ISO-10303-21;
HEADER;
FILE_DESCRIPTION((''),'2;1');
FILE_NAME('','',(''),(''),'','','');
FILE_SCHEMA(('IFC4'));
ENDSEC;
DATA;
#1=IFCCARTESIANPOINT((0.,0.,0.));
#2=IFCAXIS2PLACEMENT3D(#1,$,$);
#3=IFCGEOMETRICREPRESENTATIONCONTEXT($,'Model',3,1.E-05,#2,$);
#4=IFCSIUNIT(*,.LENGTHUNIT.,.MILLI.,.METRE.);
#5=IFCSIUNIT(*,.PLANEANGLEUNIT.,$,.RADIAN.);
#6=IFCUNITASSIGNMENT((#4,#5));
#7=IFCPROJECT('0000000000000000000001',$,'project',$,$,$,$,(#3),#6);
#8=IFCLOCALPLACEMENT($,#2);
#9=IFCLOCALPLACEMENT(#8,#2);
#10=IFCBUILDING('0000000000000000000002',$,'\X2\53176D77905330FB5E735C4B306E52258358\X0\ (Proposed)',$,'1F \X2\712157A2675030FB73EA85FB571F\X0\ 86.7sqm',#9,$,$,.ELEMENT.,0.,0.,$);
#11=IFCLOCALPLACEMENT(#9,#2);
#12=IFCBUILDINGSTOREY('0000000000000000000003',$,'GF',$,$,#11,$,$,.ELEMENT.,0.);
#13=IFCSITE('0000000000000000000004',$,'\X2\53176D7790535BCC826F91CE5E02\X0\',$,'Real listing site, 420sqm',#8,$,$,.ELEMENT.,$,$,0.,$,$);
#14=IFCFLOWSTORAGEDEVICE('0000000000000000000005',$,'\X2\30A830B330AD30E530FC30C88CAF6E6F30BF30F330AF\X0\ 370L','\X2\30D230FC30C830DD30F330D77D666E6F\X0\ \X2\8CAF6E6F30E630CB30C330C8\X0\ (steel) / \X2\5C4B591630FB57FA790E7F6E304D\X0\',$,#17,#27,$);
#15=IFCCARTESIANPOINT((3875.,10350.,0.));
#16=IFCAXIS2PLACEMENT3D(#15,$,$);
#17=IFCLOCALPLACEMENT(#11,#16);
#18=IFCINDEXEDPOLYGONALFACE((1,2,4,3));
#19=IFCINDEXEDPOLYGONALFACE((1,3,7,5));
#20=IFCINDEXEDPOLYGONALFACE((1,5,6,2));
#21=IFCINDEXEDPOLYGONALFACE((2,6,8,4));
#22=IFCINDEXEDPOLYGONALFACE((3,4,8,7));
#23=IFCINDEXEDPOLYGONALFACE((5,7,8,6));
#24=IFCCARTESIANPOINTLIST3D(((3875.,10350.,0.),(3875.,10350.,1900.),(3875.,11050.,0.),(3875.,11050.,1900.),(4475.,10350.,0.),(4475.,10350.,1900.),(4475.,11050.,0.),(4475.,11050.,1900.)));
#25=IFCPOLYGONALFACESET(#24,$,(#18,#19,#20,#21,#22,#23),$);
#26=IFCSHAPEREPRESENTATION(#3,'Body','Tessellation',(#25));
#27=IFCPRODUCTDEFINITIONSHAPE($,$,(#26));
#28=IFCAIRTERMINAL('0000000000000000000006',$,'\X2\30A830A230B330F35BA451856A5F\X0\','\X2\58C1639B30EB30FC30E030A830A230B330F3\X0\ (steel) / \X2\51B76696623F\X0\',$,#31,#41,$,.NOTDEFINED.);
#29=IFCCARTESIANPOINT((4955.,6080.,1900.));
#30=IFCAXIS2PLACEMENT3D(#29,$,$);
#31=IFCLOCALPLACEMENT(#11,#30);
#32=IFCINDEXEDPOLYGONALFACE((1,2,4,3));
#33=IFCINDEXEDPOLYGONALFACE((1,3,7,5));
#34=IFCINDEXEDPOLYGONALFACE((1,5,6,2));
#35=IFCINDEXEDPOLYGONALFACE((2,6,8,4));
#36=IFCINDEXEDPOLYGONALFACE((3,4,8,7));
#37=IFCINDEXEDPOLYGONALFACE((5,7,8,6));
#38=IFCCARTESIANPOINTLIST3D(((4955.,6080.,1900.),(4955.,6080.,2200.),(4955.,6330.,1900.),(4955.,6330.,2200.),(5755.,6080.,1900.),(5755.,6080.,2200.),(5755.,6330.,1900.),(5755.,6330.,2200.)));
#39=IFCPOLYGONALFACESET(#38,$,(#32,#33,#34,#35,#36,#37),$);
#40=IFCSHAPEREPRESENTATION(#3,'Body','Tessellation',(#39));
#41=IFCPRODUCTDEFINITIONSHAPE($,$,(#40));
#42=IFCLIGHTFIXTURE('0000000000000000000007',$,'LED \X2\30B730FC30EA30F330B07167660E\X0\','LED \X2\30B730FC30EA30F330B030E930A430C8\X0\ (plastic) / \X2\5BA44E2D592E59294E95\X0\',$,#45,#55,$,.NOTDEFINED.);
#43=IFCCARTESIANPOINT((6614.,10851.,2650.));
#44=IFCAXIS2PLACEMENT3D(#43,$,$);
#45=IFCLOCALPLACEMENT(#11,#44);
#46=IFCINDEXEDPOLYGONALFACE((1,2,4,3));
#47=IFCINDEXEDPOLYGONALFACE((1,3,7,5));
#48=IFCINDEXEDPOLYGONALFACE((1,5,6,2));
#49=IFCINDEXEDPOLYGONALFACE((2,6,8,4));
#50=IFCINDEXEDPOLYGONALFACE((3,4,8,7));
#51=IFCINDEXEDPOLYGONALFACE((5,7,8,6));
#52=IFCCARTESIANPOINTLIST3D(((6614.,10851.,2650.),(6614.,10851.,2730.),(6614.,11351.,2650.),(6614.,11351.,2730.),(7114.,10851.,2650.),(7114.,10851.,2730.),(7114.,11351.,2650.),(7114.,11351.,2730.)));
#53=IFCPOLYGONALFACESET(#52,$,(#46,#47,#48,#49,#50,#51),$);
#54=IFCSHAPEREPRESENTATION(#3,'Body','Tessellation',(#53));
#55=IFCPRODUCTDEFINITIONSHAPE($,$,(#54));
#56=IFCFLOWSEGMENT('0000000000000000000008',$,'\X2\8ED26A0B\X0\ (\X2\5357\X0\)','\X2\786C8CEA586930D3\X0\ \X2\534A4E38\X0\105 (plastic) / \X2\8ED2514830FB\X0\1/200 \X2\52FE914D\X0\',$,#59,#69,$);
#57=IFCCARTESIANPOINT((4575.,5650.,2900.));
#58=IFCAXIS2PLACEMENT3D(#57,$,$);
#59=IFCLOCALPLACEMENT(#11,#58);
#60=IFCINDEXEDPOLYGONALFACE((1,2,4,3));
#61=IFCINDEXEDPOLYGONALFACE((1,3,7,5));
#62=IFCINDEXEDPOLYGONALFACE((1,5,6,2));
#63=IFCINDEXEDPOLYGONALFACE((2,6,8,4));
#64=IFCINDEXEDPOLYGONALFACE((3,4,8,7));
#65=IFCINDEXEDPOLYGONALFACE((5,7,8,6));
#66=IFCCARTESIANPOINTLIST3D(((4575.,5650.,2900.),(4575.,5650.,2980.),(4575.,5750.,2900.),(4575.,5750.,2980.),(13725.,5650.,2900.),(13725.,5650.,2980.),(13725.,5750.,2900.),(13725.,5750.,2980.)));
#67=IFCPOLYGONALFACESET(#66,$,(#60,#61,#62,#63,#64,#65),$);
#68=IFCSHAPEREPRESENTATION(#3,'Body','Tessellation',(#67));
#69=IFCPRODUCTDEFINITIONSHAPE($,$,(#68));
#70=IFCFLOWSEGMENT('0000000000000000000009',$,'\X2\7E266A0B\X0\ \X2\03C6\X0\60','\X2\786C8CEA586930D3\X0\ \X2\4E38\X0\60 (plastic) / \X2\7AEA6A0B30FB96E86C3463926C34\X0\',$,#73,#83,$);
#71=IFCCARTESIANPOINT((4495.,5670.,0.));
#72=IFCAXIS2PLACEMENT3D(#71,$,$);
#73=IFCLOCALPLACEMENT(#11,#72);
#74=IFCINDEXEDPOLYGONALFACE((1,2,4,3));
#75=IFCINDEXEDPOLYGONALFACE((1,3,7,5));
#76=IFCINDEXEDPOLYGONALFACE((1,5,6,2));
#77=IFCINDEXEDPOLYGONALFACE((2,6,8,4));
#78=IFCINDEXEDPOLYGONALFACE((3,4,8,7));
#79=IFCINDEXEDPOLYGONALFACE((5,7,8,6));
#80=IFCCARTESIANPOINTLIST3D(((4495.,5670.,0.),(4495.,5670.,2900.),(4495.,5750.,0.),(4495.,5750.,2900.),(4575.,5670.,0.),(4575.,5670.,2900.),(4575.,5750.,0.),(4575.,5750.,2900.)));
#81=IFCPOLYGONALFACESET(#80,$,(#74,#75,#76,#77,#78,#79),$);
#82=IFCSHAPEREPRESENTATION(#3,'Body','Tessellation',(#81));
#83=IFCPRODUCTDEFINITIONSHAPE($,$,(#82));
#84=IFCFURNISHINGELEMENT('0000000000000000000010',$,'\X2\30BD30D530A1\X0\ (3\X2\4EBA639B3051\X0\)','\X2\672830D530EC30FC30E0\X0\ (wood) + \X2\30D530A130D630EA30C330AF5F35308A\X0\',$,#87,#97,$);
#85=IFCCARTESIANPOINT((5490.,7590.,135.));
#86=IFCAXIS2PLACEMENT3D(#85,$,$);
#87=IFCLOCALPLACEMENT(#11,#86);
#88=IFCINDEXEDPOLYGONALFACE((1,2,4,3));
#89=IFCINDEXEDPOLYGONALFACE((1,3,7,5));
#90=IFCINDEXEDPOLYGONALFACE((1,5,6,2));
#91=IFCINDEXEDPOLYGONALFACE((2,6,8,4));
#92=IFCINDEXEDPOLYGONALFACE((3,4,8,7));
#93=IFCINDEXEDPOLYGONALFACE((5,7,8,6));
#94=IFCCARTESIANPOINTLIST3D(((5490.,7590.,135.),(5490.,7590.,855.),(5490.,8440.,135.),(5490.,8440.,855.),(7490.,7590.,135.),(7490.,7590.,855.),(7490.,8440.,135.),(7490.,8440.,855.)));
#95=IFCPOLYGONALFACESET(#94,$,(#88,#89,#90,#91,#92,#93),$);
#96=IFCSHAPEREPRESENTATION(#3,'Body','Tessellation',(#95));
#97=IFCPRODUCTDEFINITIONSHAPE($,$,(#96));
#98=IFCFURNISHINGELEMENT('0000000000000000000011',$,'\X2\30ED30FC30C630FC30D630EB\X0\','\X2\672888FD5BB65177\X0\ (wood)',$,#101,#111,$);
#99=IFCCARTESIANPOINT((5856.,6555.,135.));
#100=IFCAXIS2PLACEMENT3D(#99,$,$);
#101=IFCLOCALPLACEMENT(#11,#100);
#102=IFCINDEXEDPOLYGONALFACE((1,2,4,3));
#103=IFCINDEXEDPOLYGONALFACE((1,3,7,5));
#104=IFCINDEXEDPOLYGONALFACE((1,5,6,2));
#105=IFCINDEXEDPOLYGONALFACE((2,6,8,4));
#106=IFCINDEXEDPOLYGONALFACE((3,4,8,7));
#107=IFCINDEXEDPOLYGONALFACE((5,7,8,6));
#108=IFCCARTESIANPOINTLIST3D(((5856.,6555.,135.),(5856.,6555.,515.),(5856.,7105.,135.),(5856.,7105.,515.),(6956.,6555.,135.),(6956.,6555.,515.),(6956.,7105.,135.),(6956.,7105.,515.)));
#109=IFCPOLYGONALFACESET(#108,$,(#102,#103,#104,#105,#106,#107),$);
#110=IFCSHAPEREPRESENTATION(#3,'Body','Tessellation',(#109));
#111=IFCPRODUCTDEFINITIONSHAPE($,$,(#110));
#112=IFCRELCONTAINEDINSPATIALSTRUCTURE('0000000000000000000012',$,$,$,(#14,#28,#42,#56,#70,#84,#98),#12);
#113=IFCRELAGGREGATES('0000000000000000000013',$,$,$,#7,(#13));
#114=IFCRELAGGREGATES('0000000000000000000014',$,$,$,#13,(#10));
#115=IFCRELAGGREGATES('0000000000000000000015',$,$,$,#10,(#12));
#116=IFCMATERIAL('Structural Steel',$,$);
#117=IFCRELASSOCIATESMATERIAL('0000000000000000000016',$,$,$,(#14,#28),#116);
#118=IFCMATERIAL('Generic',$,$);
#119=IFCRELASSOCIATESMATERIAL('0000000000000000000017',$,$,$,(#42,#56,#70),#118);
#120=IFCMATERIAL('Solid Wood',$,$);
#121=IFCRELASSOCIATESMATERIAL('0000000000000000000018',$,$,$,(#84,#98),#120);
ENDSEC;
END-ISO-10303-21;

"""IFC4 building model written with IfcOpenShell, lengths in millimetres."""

from ifc_helpers import new_model, si_unit, frame, frame_2d, origin, place, context, project, spatial, rectangle, extrude, material, element, save


model = new_model("IFC4")

# Units and contexts
model_context = context("Model", 3, precision=1e-05, world=origin())
ifc_project = project(units=[si_unit("LENGTHUNIT", "METRE", prefix="MILLI"), si_unit("PLANEANGLEUNIT", "RADIAN")], contexts=[model_context])

# Site, building, storey
site_placement = place(None, origin())
site = spatial("IfcSite", under=ifc_project, at=site_placement, Name="北海道富良野市", ObjectType="Real listing site, 420sqm", CompositionType="ELEMENT", RefElevation=0.0)
building_placement = place(site_placement, origin())
building = spatial("IfcBuilding", under=site, at=building_placement, Name="北海道・平屋の別荘 (Proposed)", ObjectType="1F 無垢材・珪藻土 86.7sqm", CompositionType="ELEMENT", ElevationOfRefHeight=0.0, ElevationOfTerrain=0.0)
storey_placement = place(building_placement, origin())
storey = spatial("IfcBuildingStorey", under=building, at=storey_placement, Name="GF", CompositionType="ELEMENT", Elevation=0.0)

# Shared definitions
ifc_material_1 = material(Name="Solid Wood")

# Shared definitions
ifc_material_2 = material(Name="Structural Steel")

# Shared definitions
ifc_material_3 = material(Name="Generic")

# Flow storage device
flow_storage_device_placement = place(storey_placement, frame((3875.0, 10350.0, 0.0)))
element("IfcFlowStorageDevice", 1, at=flow_storage_device_placement, inside=storey, material=ifc_material_2, Name="エコキュート貯湯タンク 370L", Description="ヒートポンプ給湯 貯湯ユニット (steel) / 屋外・基礎置き", context=model_context, shape_type="SweptSolid", body=[
    extrude(rectangle(XDim=600.0, YDim=700.0, at=frame_2d((300.0, 350.0))), frame((3875.0, 10350.0, 0.0)), (0.0, 0.0, 1.0), 1900.0),
])

# Air terminal
air_terminal_placement = place(storey_placement, frame((4955.0, 6080.0, 1900.0)))
element("IfcAirTerminal", 2, at=air_terminal_placement, inside=storey, material=ifc_material_2, Name="エアコン室内機", Description="壁掛ルームエアコン (steel) / 冷暖房", PredefinedType="NOTDEFINED", context=model_context, shape_type="SweptSolid", body=[
    extrude(rectangle(XDim=800.0, YDim=250.0, at=frame_2d((400.0, 125.0))), frame((4955.0, 6080.0, 1900.0)), (0.0, 0.0, 1.0), 300.0),
])

# Light fixture
light_fixture_placement = place(storey_placement, frame((6614.0, 10851.0, 2650.0)))
element("IfcLightFixture", 3, at=light_fixture_placement, inside=storey, material=ifc_material_3, Name="LED シーリング照明", Description="LED シーリングライト (plastic) / 室中央天井", PredefinedType="NOTDEFINED", context=model_context, shape_type="SweptSolid", body=[
    extrude(rectangle(XDim=500.0, YDim=500.0, at=frame_2d((250.0, 250.0))), frame((6614.0, 10851.0, 2650.0)), (0.0, 0.0, 1.0), 80.0),
])

# Flow segments
flow_segment_1_placement = place(storey_placement, frame((4575.0, 5650.0, 2900.0)))
element("IfcFlowSegment", 4, at=flow_segment_1_placement, inside=storey, material=ifc_material_3, Name="軒樋 (南)", Description="硬質塩ビ 半丸105 (plastic) / 軒先・1/200 勾配", context=model_context, shape_type="SweptSolid", body=[
    extrude(rectangle(XDim=9150.0, YDim=100.0, at=frame_2d((4575.0, 50.0))), frame((4575.0, 5650.0, 2900.0)), (0.0, 0.0, 1.0), 80.0),
])
flow_segment_2_placement = place(storey_placement, frame((4495.0, 5670.0, 0.0)))
element("IfcFlowSegment", 5, at=flow_segment_2_placement, inside=storey, material=ifc_material_3, Name="縦樋 φ60", Description="硬質塩ビ 丸60 (plastic) / 竪樋・雨水排水", context=model_context, shape_type="SweptSolid", body=[
    extrude(rectangle(XDim=80.0, YDim=80.0, at=frame_2d((40.0, 40.0))), frame((4495.0, 5670.0, 0.0)), (0.0, 0.0, 1.0), 2900.0),
])

# Furnishing elements
furnishing_1_placement = place(storey_placement, frame((5490.0, 7590.0, 135.0)))
element("IfcFurnishingElement", 6, at=furnishing_1_placement, inside=storey, material=ifc_material_1, Name="ソファ (3人掛け)", Description="木フレーム (wood) + ファブリック張り", context=model_context, shape_type="SweptSolid", body=[
    extrude(rectangle(XDim=2000.0, YDim=850.0, at=frame_2d((1000.0, 425.0))), frame((5490.0, 7590.0, 135.0)), (0.0, 0.0, 1.0), 720.0),
])
furnishing_2_placement = place(storey_placement, frame((5856.0, 6555.0, 135.0)))
element("IfcFurnishingElement", 7, at=furnishing_2_placement, inside=storey, material=ifc_material_1, Name="ローテーブル", Description="木製家具 (wood)", context=model_context, shape_type="SweptSolid", body=[
    extrude(rectangle(XDim=1100.0, YDim=550.0, at=frame_2d((550.0, 275.0))), frame((5856.0, 6555.0, 135.0)), (0.0, 0.0, 1.0), 380.0),
])

save(model, "model.ifc")
